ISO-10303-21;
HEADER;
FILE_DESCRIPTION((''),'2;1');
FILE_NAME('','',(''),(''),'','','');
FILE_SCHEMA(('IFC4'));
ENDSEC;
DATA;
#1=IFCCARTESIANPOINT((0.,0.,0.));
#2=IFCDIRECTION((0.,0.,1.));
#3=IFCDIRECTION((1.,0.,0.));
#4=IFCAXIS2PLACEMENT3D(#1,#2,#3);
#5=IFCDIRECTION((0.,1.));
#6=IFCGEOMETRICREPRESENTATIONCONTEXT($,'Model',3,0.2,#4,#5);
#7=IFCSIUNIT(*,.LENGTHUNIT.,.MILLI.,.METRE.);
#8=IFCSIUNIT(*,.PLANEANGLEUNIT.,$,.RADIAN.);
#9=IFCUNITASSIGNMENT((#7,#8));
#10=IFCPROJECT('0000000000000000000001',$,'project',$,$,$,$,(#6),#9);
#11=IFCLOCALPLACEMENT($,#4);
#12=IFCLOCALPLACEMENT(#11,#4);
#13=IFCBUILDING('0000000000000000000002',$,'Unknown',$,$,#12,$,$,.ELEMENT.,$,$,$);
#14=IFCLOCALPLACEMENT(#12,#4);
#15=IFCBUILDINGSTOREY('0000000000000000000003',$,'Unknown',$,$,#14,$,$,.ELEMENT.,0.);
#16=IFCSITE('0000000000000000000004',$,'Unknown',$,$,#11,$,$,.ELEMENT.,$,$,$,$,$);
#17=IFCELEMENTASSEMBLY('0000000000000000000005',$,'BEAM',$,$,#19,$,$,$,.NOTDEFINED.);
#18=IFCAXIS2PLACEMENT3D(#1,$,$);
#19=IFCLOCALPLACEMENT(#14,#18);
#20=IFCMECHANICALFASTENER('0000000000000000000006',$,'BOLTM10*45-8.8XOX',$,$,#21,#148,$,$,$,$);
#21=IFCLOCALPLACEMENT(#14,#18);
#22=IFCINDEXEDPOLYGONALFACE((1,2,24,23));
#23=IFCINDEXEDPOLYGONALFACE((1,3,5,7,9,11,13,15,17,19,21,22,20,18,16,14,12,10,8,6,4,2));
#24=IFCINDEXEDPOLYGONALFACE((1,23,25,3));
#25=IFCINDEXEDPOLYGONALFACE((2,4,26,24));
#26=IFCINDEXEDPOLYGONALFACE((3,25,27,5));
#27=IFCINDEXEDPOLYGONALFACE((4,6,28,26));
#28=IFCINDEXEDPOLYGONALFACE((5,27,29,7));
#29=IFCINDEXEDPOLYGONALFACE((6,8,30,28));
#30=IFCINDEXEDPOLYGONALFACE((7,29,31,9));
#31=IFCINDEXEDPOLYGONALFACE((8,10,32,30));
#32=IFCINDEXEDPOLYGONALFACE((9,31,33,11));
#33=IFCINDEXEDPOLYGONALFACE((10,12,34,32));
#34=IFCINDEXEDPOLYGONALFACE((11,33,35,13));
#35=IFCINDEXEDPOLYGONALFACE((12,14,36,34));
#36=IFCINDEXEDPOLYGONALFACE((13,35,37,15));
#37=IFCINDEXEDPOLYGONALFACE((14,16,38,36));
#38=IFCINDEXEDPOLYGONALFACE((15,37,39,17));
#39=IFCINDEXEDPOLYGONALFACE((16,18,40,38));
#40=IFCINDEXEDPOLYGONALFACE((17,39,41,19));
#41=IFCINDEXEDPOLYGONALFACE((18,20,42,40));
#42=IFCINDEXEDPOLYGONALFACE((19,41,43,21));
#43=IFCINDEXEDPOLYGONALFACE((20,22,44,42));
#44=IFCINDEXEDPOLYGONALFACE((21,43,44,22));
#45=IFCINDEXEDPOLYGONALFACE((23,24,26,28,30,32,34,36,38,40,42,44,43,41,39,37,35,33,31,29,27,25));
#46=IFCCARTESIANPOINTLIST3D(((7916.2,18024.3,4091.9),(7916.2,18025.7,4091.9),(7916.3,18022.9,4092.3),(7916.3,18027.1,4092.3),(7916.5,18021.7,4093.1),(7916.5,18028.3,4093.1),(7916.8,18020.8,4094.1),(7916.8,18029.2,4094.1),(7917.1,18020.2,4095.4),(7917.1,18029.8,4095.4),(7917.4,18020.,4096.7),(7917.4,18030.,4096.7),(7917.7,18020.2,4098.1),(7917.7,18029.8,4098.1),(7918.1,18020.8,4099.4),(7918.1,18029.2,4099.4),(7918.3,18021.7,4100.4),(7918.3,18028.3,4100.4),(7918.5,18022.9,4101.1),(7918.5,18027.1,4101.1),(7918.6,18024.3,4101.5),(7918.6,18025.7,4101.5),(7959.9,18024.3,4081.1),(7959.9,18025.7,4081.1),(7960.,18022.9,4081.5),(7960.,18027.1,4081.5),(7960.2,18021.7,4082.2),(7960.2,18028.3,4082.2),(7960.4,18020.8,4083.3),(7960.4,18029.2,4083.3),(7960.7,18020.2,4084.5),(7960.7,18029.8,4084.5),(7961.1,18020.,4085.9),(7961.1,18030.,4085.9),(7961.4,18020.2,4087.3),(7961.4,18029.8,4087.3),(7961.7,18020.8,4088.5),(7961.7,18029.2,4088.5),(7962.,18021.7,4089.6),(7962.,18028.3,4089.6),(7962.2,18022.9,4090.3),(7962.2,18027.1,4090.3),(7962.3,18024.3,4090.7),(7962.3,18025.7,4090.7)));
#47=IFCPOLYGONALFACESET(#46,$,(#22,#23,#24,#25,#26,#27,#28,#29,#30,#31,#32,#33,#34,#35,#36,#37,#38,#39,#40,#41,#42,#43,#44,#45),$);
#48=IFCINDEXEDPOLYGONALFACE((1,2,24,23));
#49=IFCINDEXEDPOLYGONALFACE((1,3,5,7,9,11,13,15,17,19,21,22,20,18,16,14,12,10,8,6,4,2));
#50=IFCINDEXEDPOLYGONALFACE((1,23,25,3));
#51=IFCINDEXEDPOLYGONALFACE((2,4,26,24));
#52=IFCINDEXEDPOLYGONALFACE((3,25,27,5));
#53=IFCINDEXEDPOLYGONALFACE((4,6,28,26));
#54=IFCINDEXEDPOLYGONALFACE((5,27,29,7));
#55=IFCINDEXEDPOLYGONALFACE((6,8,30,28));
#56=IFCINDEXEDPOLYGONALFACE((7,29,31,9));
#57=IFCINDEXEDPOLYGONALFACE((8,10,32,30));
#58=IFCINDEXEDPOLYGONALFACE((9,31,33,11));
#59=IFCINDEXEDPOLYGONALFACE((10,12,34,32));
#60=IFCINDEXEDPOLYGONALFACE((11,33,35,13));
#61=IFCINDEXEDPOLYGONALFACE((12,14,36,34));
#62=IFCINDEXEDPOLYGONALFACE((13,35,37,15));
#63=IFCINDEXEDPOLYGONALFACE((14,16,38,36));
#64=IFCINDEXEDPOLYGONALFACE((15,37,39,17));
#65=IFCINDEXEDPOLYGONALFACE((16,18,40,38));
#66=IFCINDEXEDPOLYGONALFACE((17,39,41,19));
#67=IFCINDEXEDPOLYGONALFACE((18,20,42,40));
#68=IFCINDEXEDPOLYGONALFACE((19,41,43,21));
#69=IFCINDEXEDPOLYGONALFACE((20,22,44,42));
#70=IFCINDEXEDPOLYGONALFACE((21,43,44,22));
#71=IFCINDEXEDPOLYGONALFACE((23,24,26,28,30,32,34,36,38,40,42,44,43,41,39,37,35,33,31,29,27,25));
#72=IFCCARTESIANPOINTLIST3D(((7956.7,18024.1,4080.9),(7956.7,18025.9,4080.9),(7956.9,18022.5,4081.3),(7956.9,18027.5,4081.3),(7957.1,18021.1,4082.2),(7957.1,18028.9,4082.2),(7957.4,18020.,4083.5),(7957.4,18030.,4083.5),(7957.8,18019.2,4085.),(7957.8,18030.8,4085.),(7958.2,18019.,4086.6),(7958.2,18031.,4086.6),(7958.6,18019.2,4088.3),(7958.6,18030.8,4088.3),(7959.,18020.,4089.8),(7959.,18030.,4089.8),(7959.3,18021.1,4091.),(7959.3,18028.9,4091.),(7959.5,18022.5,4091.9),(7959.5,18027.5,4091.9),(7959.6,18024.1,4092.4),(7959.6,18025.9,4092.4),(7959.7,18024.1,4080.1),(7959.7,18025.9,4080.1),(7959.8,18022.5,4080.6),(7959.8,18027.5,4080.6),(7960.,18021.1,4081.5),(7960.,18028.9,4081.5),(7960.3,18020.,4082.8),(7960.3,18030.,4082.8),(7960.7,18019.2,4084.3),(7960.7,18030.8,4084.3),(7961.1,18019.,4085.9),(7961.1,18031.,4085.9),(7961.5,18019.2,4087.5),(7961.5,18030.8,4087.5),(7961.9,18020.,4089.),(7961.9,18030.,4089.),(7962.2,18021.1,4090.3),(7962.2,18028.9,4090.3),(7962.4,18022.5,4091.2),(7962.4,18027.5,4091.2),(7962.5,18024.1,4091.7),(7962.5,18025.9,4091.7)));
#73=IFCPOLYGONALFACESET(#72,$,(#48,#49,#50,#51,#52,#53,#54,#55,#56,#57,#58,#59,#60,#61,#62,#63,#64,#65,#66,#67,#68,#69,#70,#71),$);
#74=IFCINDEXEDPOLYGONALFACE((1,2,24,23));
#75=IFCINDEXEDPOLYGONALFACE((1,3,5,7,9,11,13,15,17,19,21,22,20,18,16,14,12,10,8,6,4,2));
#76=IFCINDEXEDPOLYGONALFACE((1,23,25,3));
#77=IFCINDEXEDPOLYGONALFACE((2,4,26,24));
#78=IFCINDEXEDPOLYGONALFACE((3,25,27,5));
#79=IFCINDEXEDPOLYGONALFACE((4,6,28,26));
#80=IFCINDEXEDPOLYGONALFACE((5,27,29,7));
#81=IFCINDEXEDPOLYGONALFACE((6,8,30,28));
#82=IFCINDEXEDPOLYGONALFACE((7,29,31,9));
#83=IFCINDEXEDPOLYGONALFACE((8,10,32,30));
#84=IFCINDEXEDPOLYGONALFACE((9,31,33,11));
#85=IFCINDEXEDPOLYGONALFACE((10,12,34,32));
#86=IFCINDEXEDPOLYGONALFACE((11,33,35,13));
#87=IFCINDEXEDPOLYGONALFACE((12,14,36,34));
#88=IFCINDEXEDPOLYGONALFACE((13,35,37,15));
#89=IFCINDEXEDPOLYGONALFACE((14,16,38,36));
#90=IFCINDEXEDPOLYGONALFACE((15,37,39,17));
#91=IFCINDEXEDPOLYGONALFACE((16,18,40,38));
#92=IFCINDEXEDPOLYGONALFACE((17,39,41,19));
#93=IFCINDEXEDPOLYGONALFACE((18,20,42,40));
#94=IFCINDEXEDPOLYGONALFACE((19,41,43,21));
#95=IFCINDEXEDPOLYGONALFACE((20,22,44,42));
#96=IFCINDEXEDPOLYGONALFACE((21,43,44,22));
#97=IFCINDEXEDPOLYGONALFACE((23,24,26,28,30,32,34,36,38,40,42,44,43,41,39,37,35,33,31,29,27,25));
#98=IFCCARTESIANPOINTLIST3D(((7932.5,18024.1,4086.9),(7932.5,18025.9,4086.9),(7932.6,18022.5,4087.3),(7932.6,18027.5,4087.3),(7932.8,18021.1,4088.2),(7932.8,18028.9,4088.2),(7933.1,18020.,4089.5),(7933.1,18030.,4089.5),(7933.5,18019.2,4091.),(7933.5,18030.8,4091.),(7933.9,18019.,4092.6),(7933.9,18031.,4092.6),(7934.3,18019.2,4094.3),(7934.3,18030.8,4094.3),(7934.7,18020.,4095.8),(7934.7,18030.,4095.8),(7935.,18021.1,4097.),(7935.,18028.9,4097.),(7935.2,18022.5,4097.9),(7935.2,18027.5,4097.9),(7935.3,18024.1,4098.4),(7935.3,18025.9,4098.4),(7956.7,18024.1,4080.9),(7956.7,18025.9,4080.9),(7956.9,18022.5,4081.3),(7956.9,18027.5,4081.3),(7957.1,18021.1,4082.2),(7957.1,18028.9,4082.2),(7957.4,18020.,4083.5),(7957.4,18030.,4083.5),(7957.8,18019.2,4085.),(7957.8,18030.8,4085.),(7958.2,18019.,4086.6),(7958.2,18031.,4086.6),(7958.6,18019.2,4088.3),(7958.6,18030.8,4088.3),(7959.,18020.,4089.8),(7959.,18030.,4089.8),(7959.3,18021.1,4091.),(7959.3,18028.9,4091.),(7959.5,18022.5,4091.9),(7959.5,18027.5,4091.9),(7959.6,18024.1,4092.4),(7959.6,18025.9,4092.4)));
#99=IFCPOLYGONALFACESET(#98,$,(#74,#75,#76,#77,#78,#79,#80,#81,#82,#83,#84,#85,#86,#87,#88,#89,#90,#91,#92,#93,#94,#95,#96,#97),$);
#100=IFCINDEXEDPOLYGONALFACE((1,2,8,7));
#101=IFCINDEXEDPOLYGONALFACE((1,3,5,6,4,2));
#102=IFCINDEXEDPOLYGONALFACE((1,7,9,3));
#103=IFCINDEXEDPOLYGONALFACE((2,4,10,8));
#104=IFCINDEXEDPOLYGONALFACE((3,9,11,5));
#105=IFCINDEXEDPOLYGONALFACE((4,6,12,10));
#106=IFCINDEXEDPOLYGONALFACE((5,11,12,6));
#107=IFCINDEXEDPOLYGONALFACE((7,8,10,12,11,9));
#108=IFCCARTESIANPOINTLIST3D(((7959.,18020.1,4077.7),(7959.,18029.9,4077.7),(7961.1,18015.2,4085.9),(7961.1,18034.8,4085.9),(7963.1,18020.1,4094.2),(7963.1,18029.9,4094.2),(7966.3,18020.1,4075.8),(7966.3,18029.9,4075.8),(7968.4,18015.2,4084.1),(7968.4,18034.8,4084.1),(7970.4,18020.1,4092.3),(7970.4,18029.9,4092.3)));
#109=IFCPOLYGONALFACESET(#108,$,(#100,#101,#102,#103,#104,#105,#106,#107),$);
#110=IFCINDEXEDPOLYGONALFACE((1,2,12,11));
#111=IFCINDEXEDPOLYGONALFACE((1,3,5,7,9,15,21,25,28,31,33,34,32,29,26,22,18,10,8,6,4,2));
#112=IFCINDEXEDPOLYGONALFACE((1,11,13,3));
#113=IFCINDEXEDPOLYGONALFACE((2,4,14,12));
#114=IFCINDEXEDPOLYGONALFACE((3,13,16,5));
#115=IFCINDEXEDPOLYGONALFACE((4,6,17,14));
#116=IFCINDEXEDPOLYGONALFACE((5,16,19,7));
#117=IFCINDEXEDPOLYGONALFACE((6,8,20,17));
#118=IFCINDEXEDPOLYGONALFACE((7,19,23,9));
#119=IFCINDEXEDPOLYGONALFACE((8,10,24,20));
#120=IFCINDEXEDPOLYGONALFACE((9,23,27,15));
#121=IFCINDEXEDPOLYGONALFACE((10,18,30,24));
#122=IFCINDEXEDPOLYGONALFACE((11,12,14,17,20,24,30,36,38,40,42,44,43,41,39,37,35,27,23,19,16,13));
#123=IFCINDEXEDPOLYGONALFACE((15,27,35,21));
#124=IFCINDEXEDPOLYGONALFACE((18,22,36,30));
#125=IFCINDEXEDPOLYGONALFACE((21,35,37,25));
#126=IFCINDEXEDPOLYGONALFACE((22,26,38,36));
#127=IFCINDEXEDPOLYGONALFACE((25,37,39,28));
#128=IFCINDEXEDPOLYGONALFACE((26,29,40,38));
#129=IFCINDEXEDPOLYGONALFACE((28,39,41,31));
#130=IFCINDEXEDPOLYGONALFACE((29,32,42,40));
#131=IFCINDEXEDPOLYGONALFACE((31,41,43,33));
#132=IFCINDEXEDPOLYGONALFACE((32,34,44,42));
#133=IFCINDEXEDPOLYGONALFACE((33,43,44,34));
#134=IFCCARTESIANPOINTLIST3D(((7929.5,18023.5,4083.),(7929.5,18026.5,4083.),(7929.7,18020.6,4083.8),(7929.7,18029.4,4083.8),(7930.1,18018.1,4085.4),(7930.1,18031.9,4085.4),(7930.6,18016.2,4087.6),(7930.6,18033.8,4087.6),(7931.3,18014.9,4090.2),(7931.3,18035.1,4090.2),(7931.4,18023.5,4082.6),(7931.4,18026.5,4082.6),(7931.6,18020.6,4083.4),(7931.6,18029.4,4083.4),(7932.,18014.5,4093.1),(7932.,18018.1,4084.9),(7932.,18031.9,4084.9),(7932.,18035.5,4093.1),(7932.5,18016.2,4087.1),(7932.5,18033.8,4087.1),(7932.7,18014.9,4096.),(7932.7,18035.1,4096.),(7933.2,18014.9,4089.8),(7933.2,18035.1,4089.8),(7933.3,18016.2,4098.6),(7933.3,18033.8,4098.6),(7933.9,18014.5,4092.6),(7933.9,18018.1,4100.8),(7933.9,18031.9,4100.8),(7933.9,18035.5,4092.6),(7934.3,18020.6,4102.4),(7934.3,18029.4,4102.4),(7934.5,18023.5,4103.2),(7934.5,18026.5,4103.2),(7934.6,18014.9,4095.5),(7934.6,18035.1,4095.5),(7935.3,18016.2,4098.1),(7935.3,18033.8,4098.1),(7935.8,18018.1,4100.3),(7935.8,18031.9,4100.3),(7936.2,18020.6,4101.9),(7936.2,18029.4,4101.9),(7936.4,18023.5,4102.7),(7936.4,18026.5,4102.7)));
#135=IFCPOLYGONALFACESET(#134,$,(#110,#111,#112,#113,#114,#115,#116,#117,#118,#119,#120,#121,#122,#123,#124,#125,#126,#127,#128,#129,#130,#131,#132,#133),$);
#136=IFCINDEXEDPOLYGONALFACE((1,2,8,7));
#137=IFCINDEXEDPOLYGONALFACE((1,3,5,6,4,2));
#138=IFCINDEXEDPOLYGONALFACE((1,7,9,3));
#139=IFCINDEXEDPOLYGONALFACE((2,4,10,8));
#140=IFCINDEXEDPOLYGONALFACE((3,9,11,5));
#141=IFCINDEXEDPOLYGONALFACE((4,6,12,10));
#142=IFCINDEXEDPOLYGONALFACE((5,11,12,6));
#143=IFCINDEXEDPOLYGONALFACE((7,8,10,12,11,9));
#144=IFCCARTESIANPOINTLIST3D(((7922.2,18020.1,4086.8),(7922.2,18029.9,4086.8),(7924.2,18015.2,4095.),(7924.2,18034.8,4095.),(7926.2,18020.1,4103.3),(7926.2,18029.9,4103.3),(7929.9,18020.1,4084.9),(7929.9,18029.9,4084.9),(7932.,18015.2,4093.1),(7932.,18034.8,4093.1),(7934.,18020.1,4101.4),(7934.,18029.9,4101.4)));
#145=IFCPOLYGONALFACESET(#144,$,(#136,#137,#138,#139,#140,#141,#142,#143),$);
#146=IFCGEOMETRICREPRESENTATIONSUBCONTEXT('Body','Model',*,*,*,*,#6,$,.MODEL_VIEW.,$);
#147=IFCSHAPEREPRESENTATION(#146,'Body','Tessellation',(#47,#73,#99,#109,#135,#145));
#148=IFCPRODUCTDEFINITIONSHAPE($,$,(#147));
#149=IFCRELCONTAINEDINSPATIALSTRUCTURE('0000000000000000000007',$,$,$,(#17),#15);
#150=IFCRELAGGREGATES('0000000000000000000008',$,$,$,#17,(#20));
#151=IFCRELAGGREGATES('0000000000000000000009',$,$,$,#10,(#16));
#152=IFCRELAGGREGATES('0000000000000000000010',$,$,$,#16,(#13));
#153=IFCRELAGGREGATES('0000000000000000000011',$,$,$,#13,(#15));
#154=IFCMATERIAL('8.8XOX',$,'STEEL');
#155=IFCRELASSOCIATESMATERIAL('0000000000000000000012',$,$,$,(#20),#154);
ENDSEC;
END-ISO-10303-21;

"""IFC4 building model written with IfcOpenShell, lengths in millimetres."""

from ifc_helpers import new_model, si_unit, direction, frame, origin_with_axes, place, context, subcontext, project, spatial, line, arc, indexed_curve, outline, extrude, source, transform, mapped, material, element, aggregate, save


model = new_model("IFC4")

# Units and contexts
model_context = context("Model", 3, precision=0.2, world=origin_with_axes(), true_north=direction((0.0, 1.0)))
body_context = subcontext(model_context, "Body", "Model", "MODEL_VIEW")
ifc_project = project(units=[si_unit("LENGTHUNIT", "METRE", prefix="MILLI"), si_unit("PLANEANGLEUNIT", "RADIAN")], contexts=[model_context])

# Site, building, storey
site_placement = place(None, origin_with_axes())
site = spatial("IfcSite", under=ifc_project, at=site_placement, Name="Unknown", CompositionType="ELEMENT")
building_placement = place(site_placement, origin_with_axes())
building = spatial("IfcBuilding", under=site, at=building_placement, Name="Unknown", CompositionType="ELEMENT")
storey_placement = place(building_placement, origin_with_axes())
storey = spatial("IfcBuildingStorey", under=building, at=storey_placement, Name="Unknown", CompositionType="ELEMENT", Elevation=0.0)

# Shared definitions
ifc_material_1 = material(Name="8.8XOX", Category="STEEL")

# Element assembly, mechanical fastener
shared_shape_1 = source(origin_with_axes(), body_context, "Body", "SweptSolid", [
    extrude(outline(indexed_curve([(5.0, 0.0), (0.0, 5.0), (-5.0, 0.0), (0.0, -5.0)], segments=[arc(1, 2, 3), arc(3, 4, 1)])), frame((0.0, 0.0, 3.8), z_axis=(0.0, 0.0, -1.0), x_axis=(0.0, 1.0, 0.0)), (0.0, 0.0, 1.0), 45.0),
    extrude(outline(indexed_curve([(6.0, 0.0), (0.0, 6.0), (-6.0, 0.0), (0.0, -6.0)], segments=[arc(1, 2, 3), arc(3, 4, 1)])), frame((0.0, 0.0, 3.8), z_axis=(0.0, 0.0, -1.0), x_axis=(0.0, 1.0, 0.0)), (0.0, 0.0, 1.0), 3.0),
    extrude(outline(indexed_curve([(6.0, 0.0), (0.0, 6.0), (-6.0, 0.0), (0.0, -6.0)], segments=[arc(1, 2, 3), arc(3, 4, 1)])), frame((0.0, 0.0, 0.8), z_axis=(0.0, 0.0, -1.0), x_axis=(0.0, 1.0, 0.0)), (0.0, 0.0, 1.0), 25.0),
    extrude(outline(indexed_curve([(9.8, 0.0), (4.9, 8.5), (-4.9, 8.5), (-9.8, 0.0), (-4.9, -8.5), (4.9, -8.5)], segments=[line(1, 2, 3, 4, 5, 6, 1)])), frame((0.0, 0.0, 11.2), z_axis=(0.0, 0.0, -1.0), x_axis=(0.0, 1.0, 0.0)), (0.0, 0.0, 1.0), 7.5),
    extrude(outline(indexed_curve([(10.5, 0.0), (0.0, 10.5), (-10.5, 0.0), (0.0, -10.5)], segments=[arc(1, 2, 3), arc(3, 4, 1)])), frame((0.0, 0.0, -24.2), z_axis=(0.0, 0.0, -1.0), x_axis=(0.0, 1.0, 0.0)), (0.0, 0.0, 1.0), 2.0),
    extrude(outline(indexed_curve([(9.8, 0.0), (4.9, 8.5), (-4.9, 8.5), (-9.8, 0.0), (-4.9, -8.5), (4.9, -8.5)], segments=[line(1, 2, 3, 4, 5, 6, 1)])), frame((0.0, 0.0, -26.2), z_axis=(0.0, 0.0, -1.0), x_axis=(0.0, 1.0, 0.0)), (0.0, 0.0, 1.0), 8.0),
])
assembly_1_placement = place(storey_placement, frame((7947.2, 18000.0, 4094.5), z_axis=(0.970613, 0.0, -0.240648), x_axis=(0.0, 1.0, 0.0)))
assembly_1 = element("IfcElementAssembly", 1, at=assembly_1_placement, inside=storey, Name="BEAM", PredefinedType="NOTDEFINED")
mechanical_fastener_1_placement = place(assembly_1_placement, frame((25.0, -5.0, 11.8), z_axis=(0.0, 0.0, 1.0), x_axis=(0.0, 1.0, 0.0)))
mechanical_fastener_1 = element("IfcMechanicalFastener", 2, at=mechanical_fastener_1_placement, material=ifc_material_1, Name="BOLTM10*45-8.8XOX", context=body_context, shape_type="MappedRepresentation", body=[
    mapped(shared_shape_1, transform((0.0, 0.0, 0.0))),
])
aggregate(assembly_1, [mechanical_fastener_1])

save(model, "model.ifc")
